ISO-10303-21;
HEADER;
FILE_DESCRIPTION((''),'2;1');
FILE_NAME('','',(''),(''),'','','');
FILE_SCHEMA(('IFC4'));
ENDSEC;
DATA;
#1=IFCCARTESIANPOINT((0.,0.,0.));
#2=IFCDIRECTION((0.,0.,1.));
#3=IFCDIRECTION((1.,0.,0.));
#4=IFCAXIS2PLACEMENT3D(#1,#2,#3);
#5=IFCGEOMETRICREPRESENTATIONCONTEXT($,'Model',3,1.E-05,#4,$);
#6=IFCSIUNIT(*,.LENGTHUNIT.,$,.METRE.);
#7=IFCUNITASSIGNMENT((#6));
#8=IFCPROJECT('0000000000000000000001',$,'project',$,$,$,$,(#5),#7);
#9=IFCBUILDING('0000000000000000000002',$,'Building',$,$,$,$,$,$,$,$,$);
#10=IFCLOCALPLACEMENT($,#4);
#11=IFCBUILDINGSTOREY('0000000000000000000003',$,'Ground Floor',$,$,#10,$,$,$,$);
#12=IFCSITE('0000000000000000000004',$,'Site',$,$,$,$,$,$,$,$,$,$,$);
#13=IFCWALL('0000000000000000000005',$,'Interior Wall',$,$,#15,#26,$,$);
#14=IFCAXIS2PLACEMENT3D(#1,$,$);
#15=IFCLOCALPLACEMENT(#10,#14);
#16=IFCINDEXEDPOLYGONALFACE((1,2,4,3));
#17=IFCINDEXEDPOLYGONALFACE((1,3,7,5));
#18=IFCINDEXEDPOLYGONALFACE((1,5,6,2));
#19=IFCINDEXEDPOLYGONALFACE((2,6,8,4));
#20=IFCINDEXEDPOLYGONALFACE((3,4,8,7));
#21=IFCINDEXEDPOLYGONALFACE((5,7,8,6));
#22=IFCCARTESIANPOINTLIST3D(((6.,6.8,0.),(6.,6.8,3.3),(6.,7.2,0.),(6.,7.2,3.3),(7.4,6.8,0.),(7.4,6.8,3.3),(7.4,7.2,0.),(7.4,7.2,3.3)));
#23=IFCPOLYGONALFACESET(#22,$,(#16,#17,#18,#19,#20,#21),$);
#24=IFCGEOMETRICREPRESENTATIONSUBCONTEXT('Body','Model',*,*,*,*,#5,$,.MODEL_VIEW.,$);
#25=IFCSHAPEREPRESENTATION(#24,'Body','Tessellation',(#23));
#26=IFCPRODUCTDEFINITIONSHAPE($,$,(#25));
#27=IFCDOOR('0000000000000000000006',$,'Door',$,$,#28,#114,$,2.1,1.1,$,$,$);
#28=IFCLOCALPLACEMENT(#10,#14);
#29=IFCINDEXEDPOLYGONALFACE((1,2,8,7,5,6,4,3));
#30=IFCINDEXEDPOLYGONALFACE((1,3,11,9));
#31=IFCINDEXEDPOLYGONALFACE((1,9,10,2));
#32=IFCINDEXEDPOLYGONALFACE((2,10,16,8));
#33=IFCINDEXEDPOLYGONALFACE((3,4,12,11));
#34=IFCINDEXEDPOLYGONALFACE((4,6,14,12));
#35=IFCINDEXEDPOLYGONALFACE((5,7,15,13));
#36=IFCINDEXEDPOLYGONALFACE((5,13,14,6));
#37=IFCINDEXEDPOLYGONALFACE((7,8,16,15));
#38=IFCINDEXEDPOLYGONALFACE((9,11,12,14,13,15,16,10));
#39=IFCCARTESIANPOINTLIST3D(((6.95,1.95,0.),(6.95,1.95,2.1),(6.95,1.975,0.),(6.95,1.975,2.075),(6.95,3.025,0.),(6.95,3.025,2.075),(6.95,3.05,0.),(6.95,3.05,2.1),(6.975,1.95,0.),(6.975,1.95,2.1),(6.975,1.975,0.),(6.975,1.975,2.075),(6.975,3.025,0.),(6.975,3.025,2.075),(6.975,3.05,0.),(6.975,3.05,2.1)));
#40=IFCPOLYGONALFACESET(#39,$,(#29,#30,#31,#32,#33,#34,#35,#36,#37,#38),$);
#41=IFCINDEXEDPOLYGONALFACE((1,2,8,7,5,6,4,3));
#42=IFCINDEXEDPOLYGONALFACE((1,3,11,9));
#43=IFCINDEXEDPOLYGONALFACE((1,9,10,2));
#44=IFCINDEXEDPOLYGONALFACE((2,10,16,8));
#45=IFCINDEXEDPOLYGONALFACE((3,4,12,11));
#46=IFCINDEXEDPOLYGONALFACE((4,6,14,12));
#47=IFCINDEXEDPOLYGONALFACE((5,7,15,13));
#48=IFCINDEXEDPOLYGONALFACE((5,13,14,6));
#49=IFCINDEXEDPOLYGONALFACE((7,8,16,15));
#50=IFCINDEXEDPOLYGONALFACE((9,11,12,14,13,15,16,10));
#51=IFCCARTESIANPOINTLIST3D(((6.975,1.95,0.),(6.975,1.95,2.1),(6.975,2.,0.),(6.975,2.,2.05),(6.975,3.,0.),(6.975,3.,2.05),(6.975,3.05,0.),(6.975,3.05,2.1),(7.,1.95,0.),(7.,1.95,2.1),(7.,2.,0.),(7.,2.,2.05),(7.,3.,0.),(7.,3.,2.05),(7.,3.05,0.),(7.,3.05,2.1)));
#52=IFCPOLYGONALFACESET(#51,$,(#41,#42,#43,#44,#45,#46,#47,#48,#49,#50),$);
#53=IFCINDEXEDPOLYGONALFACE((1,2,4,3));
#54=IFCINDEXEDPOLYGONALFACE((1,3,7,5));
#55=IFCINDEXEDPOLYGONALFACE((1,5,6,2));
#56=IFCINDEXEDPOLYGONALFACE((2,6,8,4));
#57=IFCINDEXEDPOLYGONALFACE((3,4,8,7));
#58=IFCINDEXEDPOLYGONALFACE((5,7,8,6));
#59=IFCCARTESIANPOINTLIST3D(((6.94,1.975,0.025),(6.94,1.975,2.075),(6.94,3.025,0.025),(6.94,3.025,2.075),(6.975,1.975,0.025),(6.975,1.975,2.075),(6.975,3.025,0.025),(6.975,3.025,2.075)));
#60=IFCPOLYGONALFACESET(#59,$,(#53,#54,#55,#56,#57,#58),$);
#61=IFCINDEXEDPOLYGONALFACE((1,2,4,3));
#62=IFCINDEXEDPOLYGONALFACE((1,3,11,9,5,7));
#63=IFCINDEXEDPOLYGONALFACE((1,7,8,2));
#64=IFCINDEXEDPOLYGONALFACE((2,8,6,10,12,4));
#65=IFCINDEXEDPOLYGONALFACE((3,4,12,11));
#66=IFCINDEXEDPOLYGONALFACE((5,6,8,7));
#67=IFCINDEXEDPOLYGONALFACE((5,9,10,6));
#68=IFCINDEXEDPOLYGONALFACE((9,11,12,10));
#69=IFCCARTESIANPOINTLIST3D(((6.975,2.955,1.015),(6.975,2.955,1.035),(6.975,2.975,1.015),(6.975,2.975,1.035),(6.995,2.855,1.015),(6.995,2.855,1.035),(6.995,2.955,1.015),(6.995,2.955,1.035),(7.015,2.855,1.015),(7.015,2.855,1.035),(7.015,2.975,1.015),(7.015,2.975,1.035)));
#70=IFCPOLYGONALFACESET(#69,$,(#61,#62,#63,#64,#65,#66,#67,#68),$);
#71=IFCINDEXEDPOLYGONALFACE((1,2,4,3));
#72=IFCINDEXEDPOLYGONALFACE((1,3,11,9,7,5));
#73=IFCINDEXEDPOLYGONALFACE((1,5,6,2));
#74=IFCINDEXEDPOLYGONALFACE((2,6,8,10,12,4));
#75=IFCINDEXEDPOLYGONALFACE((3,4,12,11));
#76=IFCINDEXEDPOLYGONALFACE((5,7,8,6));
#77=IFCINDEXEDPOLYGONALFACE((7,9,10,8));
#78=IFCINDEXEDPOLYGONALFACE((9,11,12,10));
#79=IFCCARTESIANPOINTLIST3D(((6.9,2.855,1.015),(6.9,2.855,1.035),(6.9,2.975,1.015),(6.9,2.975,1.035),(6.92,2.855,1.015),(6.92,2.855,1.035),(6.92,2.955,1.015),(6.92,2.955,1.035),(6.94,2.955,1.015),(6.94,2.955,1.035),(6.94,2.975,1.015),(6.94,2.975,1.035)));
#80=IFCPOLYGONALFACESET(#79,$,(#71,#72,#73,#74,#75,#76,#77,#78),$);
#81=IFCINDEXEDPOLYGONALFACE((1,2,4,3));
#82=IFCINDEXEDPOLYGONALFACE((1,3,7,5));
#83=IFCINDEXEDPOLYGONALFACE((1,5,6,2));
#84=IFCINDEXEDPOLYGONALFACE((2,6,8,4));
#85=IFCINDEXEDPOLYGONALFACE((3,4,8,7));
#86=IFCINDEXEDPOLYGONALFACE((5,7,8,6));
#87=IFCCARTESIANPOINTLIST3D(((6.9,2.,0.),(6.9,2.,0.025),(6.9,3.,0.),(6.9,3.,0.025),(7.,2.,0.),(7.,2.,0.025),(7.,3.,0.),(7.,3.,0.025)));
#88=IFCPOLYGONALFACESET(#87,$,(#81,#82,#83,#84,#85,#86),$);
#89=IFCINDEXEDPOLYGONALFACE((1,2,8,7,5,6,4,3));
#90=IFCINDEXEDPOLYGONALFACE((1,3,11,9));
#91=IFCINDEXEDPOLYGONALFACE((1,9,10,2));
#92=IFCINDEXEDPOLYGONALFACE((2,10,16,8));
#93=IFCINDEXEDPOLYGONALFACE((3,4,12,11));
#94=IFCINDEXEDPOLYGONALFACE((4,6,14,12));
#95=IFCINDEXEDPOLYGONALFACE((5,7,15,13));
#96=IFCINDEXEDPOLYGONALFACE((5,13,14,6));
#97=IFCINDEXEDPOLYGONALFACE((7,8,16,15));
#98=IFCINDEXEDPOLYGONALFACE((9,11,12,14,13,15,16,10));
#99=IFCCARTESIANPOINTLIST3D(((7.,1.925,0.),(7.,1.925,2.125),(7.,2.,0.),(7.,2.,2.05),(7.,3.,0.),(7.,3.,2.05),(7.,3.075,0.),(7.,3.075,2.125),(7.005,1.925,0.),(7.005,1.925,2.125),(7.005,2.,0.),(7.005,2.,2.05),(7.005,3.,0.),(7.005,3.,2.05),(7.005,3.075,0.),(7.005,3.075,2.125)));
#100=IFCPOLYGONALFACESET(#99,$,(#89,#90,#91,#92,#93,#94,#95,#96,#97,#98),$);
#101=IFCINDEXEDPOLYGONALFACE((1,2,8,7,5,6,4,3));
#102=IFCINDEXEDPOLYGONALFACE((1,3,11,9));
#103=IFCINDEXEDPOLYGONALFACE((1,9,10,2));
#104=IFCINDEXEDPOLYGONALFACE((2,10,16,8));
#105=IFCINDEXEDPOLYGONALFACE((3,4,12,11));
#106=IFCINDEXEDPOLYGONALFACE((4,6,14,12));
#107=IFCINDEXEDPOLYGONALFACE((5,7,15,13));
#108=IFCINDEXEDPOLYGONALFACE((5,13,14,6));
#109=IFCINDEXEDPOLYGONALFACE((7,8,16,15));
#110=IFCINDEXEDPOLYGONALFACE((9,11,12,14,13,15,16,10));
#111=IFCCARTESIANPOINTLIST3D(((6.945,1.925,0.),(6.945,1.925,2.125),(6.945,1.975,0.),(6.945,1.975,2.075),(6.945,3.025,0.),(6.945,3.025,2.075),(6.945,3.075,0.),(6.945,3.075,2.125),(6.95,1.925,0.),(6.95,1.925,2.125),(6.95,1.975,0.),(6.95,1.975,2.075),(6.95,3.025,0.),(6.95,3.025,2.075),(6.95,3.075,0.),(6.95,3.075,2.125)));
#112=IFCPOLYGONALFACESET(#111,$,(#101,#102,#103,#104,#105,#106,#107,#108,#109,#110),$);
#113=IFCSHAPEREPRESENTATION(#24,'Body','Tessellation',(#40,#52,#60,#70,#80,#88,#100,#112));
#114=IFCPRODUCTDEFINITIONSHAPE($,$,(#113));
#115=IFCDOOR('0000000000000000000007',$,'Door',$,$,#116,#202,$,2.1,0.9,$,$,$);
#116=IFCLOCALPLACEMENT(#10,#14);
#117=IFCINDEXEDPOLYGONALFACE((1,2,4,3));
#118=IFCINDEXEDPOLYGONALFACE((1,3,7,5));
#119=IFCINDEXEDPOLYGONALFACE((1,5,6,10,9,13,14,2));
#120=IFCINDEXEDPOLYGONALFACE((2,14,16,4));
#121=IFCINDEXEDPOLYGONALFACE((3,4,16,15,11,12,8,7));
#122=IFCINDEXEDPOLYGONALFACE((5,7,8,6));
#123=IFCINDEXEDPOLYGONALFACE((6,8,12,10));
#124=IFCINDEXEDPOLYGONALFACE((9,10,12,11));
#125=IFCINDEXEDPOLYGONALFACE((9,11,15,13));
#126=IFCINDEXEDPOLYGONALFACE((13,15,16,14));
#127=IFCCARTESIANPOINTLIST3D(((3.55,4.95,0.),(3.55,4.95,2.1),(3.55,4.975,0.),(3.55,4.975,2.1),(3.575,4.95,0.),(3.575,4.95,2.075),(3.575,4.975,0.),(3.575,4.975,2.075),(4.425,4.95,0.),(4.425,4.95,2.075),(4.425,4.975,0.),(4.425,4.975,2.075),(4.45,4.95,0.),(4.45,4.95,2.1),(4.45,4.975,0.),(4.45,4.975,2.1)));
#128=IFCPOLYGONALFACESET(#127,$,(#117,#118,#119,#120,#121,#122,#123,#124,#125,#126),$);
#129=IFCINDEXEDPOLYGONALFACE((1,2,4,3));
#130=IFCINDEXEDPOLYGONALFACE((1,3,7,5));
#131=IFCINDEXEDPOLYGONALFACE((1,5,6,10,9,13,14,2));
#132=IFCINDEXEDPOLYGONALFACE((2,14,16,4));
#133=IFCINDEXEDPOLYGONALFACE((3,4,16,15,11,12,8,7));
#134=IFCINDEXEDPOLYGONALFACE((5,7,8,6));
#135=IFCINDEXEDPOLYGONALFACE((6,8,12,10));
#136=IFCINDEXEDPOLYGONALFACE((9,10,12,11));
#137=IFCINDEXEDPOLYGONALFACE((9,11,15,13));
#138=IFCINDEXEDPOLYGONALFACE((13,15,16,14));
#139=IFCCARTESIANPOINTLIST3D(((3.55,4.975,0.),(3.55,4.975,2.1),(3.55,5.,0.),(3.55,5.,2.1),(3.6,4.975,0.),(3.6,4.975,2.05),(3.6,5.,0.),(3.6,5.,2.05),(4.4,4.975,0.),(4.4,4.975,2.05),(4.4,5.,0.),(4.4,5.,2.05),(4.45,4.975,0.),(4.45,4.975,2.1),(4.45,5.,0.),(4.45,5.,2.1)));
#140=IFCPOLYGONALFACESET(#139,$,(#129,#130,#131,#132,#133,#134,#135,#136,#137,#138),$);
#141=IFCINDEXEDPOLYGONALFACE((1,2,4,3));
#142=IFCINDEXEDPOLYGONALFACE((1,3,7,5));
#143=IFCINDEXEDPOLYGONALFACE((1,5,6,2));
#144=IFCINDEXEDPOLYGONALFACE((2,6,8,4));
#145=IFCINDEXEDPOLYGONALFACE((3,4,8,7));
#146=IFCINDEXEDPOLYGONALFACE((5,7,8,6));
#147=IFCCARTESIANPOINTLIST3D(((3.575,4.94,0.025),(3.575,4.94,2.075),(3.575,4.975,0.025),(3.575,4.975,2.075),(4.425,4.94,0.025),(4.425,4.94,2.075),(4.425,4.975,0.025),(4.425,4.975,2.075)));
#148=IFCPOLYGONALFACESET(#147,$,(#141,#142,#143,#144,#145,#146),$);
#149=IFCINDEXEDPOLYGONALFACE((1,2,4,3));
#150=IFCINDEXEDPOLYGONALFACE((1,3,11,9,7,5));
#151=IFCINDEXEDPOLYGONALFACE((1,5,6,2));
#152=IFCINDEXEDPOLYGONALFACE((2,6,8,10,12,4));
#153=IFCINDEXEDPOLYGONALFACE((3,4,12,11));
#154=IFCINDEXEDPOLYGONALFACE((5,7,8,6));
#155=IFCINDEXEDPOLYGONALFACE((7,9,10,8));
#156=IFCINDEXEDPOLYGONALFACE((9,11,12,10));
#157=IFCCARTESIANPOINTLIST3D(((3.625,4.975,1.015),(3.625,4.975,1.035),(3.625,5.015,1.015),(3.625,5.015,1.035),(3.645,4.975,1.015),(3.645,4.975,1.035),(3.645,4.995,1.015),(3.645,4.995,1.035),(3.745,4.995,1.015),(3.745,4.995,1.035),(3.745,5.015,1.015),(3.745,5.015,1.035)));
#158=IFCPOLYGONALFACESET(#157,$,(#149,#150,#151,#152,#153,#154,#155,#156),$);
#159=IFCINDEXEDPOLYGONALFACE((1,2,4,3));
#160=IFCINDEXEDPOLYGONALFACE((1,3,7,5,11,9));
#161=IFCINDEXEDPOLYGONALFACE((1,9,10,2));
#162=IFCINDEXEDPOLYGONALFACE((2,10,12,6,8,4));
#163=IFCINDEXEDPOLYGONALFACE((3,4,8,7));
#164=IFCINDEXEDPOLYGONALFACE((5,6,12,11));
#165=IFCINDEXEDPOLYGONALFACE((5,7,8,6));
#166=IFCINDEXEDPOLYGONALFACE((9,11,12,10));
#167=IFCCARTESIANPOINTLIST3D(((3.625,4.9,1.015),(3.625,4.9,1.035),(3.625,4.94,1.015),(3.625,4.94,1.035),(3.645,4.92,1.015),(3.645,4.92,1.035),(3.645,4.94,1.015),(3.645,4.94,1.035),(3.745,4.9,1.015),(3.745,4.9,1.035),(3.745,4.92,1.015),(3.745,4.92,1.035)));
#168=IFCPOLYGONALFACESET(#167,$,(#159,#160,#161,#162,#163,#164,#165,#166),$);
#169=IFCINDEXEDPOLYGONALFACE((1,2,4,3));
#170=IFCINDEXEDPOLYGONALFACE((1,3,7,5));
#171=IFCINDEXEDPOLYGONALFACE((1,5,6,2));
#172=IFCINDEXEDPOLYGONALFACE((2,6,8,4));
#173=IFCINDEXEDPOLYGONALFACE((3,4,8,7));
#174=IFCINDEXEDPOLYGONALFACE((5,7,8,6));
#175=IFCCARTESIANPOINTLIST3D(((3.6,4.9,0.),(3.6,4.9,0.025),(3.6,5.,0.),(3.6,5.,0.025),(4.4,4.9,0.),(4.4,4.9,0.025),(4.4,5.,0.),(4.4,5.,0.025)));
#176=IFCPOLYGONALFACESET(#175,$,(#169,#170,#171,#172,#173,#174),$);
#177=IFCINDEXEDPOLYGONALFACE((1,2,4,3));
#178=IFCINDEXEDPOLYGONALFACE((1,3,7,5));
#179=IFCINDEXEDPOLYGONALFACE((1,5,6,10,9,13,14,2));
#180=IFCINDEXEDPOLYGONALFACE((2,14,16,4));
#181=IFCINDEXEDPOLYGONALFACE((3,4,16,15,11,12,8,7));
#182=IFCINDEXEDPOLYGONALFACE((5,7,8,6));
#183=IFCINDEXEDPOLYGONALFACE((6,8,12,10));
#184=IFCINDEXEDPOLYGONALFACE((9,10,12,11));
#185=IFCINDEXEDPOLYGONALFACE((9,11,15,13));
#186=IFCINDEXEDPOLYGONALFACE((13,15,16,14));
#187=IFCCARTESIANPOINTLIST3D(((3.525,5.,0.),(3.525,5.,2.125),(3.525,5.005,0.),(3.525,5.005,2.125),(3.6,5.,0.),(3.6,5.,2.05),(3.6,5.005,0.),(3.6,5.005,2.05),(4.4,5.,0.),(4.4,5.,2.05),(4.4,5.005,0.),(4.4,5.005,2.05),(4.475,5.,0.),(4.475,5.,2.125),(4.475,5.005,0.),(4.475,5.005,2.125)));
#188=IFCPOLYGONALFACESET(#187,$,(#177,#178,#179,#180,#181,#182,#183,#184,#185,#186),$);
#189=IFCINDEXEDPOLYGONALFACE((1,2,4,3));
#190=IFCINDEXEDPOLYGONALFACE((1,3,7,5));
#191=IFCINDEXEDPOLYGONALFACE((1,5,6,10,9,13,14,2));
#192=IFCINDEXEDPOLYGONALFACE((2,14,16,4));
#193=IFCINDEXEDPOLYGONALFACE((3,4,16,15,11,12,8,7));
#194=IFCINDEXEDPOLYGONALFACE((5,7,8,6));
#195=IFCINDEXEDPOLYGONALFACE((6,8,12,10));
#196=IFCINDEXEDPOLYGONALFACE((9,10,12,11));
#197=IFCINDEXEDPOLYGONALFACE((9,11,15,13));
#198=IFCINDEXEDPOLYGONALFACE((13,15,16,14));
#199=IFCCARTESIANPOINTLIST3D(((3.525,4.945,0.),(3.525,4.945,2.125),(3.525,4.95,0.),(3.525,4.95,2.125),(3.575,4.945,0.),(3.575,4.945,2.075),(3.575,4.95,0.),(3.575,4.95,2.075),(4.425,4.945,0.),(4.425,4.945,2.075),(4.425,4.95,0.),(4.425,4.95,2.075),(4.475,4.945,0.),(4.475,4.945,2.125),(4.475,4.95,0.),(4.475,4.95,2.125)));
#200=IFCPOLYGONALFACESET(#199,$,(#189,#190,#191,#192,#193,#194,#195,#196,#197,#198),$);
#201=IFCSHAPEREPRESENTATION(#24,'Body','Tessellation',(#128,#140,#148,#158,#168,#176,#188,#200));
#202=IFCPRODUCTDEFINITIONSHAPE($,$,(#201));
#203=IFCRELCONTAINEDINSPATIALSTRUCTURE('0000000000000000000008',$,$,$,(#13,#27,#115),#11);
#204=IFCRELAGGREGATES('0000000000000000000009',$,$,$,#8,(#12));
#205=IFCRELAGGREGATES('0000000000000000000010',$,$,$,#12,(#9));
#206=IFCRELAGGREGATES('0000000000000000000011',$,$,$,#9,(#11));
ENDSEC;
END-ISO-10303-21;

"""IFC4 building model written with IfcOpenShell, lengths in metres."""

from ifc_helpers import new_model, si_unit, frame, origin_with_axes, place, context, subcontext, project, spatial, line, indexed_curve, outline, extrude, element, save


model = new_model("IFC4")

# Units and contexts
model_context = context("Model", 3, precision=1e-05, world=origin_with_axes())
body_context = subcontext(model_context, "Body", "Model", "MODEL_VIEW")
ifc_project = project(units=[si_unit("LENGTHUNIT", "METRE")], contexts=[model_context])

# Site, building, storey
site = spatial("IfcSite", under=ifc_project, Name="Site")
building = spatial("IfcBuilding", under=site, Name="Building")
storey_placement = place(None, origin_with_axes())
storey = spatial("IfcBuildingStorey", under=building, at=storey_placement, Name="Ground Floor")

# Wall
for number, where, z_axis, x_axis, name in (
    (1, (7.4, 7.0, 0.0), (0.0, 0.0, 1.0), (-1.0, 0.0, 0.0), "Interior Wall"),
):
    element("IfcWall", number, at=place(storey_placement, frame(where, z_axis=z_axis, x_axis=x_axis)), inside=storey, Name=name, context=body_context, shape_type="SweptSolid", body=[
        extrude(outline(indexed_curve([(0.0, 0.0), (0.0, 0.4), (1.4, 0.4), (1.4, 0.0), (0.0, 0.0)], self_intersect=False)), frame((0.0, -0.2, 0.0), z_axis=(0.0, 0.0, 1.0), x_axis=(1.0, 0.0, 0.0)), (0.0, 0.0, 1.0), 3.3),
    ])

# Doors
door_1_placement = place(storey_placement, frame((7.0, 1.95, 0.0), z_axis=(0.0, 0.0, 1.0), x_axis=(0.0, 1.0, 0.0)))
element("IfcDoor", 2, at=door_1_placement, inside=storey, Name="Door", OverallHeight=2.1, OverallWidth=1.1, context=body_context, shape_type="SweptSolid", body=[
    extrude(outline(indexed_curve([(0.0, 0.0), (0.0, 2.1), (1.1, 2.1), (1.1, 0.0), (1.075, 0.0), (1.075, 2.075), (0.025, 2.075), (0.025, 0.0)], segments=[line(1, 2, 3, 4, 5, 6, 7, 8, 1)])), frame((0.0, 0.025, 0.0), z_axis=(0.0, -1.0, 0.0), x_axis=(1.0, 0.0, 0.0)), (0.0, 0.0, -1.0), 0.025),
    extrude(outline(indexed_curve([(0.0, 0.0), (0.0, 2.1), (1.1, 2.1), (1.1, 0.0), (1.05, 0.0), (1.05, 2.05), (0.05, 2.05), (0.05, 0.0)], segments=[line(1, 2, 3, 4, 5, 6, 7, 8, 1)])), frame((0.0, 0.0, 0.0), z_axis=(0.0, -1.0, 0.0), x_axis=(1.0, 0.0, 0.0)), (0.0, 0.0, -1.0), 0.025),
    extrude(outline(indexed_curve([(0.0, 0.0), (1.05, 0.0), (1.05, 0.035), (0.0, 0.035)], segments=[line(1, 2, 3, 4, 1)])), frame((0.025, 0.025, 0.025), z_axis=(0.0, 0.0, 1.0), x_axis=(1.0, 0.0, 0.0)), (0.0, 0.0, 1.0), 2.05),
    extrude(outline(indexed_curve([(0.0, 0.0), (0.0, -0.04), (-0.12, -0.04), (-0.12, -0.02), (-0.02, -0.02), (-0.02, 0.0)], segments=[line(1, 2, 3, 4, 5, 6, 1)])), frame((1.025, 0.025, 1.015), z_axis=(0.0, 0.0, 1.0), x_axis=(1.0, 0.0, 0.0)), (0.0, 0.0, 1.0), 0.02),
    extrude(outline(indexed_curve([(0.0, 0.0), (0.0, 0.04), (-0.12, 0.04), (-0.12, 0.02), (-0.02, 0.02), (-0.02, 0.0)], segments=[line(1, 2, 3, 4, 5, 6, 1)])), frame((1.025, 0.06, 1.015), z_axis=(0.0, 0.0, 1.0), x_axis=(1.0, 0.0, 0.0)), (0.0, 0.0, 1.0), 0.02),
    extrude(outline(indexed_curve([(0.0, 0.0), (1.0, 0.0), (1.0, 0.1), (0.0, 0.1)], segments=[line(1, 2, 3, 4, 1)])), frame((0.05, 0.0, 0.0), z_axis=(0.0, 0.0, 1.0), x_axis=(1.0, 0.0, 0.0)), (0.0, 0.0, 1.0), 0.025),
    extrude(outline(indexed_curve([(0.0, 0.0), (0.0, 2.125), (1.15, 2.125), (1.15, 0.0), (1.075, 0.0), (1.075, 2.05), (0.075, 2.05), (0.075, 0.0)], segments=[line(1, 2, 3, 4, 5, 6, 7, 8, 1)])), frame((-0.025, -0.005, 0.0), z_axis=(0.0, -1.0, 0.0), x_axis=(1.0, 0.0, 0.0)), (0.0, 0.0, -1.0), 0.005),
    extrude(outline(indexed_curve([(0.0, 0.0), (0.0, 2.125), (1.15, 2.125), (1.15, 0.0), (1.1, 0.0), (1.1, 2.075), (0.05, 2.075), (0.05, 0.0)], segments=[line(1, 2, 3, 4, 5, 6, 7, 8, 1)])), frame((-0.025, 0.05, 0.0), z_axis=(0.0, -1.0, 0.0), x_axis=(1.0, 0.0, 0.0)), (0.0, 0.0, -1.0), 0.005),
])
door_2_placement = place(storey_placement, frame((4.45, 5.0, 0.0), z_axis=(0.0, 0.0, 1.0), x_axis=(-1.0, 0.0, 0.0)))
element("IfcDoor", 3, at=door_2_placement, inside=storey, Name="Door", OverallHeight=2.1, OverallWidth=0.9, context=body_context, shape_type="SweptSolid", body=[
    extrude(outline(indexed_curve([(0.0, 0.0), (0.0, 2.1), (0.9, 2.1), (0.9, 0.0), (0.875, 0.0), (0.875, 2.075), (0.025, 2.075), (0.025, 0.0)], segments=[line(1, 2, 3, 4, 5, 6, 7, 8, 1)])), frame((0.0, 0.025, 0.0), z_axis=(0.0, -1.0, 0.0), x_axis=(1.0, 0.0, 0.0)), (0.0, 0.0, -1.0), 0.025),
    extrude(outline(indexed_curve([(0.0, 0.0), (0.0, 2.1), (0.9, 2.1), (0.9, 0.0), (0.85, 0.0), (0.85, 2.05), (0.05, 2.05), (0.05, 0.0)], segments=[line(1, 2, 3, 4, 5, 6, 7, 8, 1)])), frame((0.0, 0.0, 0.0), z_axis=(0.0, -1.0, 0.0), x_axis=(1.0, 0.0, 0.0)), (0.0, 0.0, -1.0), 0.025),
    extrude(outline(indexed_curve([(0.0, 0.0), (0.85, 0.0), (0.85, 0.035), (0.0, 0.035)], segments=[line(1, 2, 3, 4, 1)])), frame((0.025, 0.025, 0.025), z_axis=(0.0, 0.0, 1.0), x_axis=(1.0, 0.0, 0.0)), (0.0, 0.0, 1.0), 2.05),
    extrude(outline(indexed_curve([(0.0, 0.0), (0.0, -0.04), (-0.12, -0.04), (-0.12, -0.02), (-0.02, -0.02), (-0.02, 0.0)], segments=[line(1, 2, 3, 4, 5, 6, 1)])), frame((0.825, 0.025, 1.015), z_axis=(0.0, 0.0, 1.0), x_axis=(1.0, 0.0, 0.0)), (0.0, 0.0, 1.0), 0.02),
    extrude(outline(indexed_curve([(0.0, 0.0), (0.0, 0.04), (-0.12, 0.04), (-0.12, 0.02), (-0.02, 0.02), (-0.02, 0.0)], segments=[line(1, 2, 3, 4, 5, 6, 1)])), frame((0.825, 0.06, 1.015), z_axis=(0.0, 0.0, 1.0), x_axis=(1.0, 0.0, 0.0)), (0.0, 0.0, 1.0), 0.02),
    extrude(outline(indexed_curve([(0.0, 0.0), (0.8, 0.0), (0.8, 0.1), (0.0, 0.1)], segments=[line(1, 2, 3, 4, 1)])), frame((0.05, 0.0, 0.0), z_axis=(0.0, 0.0, 1.0), x_axis=(1.0, 0.0, 0.0)), (0.0, 0.0, 1.0), 0.025),
    extrude(outline(indexed_curve([(0.0, 0.0), (0.0, 2.125), (0.95, 2.125), (0.95, 0.0), (0.875, 0.0), (0.875, 2.05), (0.075, 2.05), (0.075, 0.0)], segments=[line(1, 2, 3, 4, 5, 6, 7, 8, 1)])), frame((-0.025, -0.005, 0.0), z_axis=(0.0, -1.0, 0.0), x_axis=(1.0, 0.0, 0.0)), (0.0, 0.0, -1.0), 0.005),
    extrude(outline(indexed_curve([(0.0, 0.0), (0.0, 2.125), (0.95, 2.125), (0.95, 0.0), (0.9, 0.0), (0.9, 2.075), (0.05, 2.075), (0.05, 0.0)], segments=[line(1, 2, 3, 4, 5, 6, 7, 8, 1)])), frame((-0.025, 0.05, 0.0), z_axis=(0.0, -1.0, 0.0), x_axis=(1.0, 0.0, 0.0)), (0.0, 0.0, -1.0), 0.005),
])

save(model, "model.ifc")
